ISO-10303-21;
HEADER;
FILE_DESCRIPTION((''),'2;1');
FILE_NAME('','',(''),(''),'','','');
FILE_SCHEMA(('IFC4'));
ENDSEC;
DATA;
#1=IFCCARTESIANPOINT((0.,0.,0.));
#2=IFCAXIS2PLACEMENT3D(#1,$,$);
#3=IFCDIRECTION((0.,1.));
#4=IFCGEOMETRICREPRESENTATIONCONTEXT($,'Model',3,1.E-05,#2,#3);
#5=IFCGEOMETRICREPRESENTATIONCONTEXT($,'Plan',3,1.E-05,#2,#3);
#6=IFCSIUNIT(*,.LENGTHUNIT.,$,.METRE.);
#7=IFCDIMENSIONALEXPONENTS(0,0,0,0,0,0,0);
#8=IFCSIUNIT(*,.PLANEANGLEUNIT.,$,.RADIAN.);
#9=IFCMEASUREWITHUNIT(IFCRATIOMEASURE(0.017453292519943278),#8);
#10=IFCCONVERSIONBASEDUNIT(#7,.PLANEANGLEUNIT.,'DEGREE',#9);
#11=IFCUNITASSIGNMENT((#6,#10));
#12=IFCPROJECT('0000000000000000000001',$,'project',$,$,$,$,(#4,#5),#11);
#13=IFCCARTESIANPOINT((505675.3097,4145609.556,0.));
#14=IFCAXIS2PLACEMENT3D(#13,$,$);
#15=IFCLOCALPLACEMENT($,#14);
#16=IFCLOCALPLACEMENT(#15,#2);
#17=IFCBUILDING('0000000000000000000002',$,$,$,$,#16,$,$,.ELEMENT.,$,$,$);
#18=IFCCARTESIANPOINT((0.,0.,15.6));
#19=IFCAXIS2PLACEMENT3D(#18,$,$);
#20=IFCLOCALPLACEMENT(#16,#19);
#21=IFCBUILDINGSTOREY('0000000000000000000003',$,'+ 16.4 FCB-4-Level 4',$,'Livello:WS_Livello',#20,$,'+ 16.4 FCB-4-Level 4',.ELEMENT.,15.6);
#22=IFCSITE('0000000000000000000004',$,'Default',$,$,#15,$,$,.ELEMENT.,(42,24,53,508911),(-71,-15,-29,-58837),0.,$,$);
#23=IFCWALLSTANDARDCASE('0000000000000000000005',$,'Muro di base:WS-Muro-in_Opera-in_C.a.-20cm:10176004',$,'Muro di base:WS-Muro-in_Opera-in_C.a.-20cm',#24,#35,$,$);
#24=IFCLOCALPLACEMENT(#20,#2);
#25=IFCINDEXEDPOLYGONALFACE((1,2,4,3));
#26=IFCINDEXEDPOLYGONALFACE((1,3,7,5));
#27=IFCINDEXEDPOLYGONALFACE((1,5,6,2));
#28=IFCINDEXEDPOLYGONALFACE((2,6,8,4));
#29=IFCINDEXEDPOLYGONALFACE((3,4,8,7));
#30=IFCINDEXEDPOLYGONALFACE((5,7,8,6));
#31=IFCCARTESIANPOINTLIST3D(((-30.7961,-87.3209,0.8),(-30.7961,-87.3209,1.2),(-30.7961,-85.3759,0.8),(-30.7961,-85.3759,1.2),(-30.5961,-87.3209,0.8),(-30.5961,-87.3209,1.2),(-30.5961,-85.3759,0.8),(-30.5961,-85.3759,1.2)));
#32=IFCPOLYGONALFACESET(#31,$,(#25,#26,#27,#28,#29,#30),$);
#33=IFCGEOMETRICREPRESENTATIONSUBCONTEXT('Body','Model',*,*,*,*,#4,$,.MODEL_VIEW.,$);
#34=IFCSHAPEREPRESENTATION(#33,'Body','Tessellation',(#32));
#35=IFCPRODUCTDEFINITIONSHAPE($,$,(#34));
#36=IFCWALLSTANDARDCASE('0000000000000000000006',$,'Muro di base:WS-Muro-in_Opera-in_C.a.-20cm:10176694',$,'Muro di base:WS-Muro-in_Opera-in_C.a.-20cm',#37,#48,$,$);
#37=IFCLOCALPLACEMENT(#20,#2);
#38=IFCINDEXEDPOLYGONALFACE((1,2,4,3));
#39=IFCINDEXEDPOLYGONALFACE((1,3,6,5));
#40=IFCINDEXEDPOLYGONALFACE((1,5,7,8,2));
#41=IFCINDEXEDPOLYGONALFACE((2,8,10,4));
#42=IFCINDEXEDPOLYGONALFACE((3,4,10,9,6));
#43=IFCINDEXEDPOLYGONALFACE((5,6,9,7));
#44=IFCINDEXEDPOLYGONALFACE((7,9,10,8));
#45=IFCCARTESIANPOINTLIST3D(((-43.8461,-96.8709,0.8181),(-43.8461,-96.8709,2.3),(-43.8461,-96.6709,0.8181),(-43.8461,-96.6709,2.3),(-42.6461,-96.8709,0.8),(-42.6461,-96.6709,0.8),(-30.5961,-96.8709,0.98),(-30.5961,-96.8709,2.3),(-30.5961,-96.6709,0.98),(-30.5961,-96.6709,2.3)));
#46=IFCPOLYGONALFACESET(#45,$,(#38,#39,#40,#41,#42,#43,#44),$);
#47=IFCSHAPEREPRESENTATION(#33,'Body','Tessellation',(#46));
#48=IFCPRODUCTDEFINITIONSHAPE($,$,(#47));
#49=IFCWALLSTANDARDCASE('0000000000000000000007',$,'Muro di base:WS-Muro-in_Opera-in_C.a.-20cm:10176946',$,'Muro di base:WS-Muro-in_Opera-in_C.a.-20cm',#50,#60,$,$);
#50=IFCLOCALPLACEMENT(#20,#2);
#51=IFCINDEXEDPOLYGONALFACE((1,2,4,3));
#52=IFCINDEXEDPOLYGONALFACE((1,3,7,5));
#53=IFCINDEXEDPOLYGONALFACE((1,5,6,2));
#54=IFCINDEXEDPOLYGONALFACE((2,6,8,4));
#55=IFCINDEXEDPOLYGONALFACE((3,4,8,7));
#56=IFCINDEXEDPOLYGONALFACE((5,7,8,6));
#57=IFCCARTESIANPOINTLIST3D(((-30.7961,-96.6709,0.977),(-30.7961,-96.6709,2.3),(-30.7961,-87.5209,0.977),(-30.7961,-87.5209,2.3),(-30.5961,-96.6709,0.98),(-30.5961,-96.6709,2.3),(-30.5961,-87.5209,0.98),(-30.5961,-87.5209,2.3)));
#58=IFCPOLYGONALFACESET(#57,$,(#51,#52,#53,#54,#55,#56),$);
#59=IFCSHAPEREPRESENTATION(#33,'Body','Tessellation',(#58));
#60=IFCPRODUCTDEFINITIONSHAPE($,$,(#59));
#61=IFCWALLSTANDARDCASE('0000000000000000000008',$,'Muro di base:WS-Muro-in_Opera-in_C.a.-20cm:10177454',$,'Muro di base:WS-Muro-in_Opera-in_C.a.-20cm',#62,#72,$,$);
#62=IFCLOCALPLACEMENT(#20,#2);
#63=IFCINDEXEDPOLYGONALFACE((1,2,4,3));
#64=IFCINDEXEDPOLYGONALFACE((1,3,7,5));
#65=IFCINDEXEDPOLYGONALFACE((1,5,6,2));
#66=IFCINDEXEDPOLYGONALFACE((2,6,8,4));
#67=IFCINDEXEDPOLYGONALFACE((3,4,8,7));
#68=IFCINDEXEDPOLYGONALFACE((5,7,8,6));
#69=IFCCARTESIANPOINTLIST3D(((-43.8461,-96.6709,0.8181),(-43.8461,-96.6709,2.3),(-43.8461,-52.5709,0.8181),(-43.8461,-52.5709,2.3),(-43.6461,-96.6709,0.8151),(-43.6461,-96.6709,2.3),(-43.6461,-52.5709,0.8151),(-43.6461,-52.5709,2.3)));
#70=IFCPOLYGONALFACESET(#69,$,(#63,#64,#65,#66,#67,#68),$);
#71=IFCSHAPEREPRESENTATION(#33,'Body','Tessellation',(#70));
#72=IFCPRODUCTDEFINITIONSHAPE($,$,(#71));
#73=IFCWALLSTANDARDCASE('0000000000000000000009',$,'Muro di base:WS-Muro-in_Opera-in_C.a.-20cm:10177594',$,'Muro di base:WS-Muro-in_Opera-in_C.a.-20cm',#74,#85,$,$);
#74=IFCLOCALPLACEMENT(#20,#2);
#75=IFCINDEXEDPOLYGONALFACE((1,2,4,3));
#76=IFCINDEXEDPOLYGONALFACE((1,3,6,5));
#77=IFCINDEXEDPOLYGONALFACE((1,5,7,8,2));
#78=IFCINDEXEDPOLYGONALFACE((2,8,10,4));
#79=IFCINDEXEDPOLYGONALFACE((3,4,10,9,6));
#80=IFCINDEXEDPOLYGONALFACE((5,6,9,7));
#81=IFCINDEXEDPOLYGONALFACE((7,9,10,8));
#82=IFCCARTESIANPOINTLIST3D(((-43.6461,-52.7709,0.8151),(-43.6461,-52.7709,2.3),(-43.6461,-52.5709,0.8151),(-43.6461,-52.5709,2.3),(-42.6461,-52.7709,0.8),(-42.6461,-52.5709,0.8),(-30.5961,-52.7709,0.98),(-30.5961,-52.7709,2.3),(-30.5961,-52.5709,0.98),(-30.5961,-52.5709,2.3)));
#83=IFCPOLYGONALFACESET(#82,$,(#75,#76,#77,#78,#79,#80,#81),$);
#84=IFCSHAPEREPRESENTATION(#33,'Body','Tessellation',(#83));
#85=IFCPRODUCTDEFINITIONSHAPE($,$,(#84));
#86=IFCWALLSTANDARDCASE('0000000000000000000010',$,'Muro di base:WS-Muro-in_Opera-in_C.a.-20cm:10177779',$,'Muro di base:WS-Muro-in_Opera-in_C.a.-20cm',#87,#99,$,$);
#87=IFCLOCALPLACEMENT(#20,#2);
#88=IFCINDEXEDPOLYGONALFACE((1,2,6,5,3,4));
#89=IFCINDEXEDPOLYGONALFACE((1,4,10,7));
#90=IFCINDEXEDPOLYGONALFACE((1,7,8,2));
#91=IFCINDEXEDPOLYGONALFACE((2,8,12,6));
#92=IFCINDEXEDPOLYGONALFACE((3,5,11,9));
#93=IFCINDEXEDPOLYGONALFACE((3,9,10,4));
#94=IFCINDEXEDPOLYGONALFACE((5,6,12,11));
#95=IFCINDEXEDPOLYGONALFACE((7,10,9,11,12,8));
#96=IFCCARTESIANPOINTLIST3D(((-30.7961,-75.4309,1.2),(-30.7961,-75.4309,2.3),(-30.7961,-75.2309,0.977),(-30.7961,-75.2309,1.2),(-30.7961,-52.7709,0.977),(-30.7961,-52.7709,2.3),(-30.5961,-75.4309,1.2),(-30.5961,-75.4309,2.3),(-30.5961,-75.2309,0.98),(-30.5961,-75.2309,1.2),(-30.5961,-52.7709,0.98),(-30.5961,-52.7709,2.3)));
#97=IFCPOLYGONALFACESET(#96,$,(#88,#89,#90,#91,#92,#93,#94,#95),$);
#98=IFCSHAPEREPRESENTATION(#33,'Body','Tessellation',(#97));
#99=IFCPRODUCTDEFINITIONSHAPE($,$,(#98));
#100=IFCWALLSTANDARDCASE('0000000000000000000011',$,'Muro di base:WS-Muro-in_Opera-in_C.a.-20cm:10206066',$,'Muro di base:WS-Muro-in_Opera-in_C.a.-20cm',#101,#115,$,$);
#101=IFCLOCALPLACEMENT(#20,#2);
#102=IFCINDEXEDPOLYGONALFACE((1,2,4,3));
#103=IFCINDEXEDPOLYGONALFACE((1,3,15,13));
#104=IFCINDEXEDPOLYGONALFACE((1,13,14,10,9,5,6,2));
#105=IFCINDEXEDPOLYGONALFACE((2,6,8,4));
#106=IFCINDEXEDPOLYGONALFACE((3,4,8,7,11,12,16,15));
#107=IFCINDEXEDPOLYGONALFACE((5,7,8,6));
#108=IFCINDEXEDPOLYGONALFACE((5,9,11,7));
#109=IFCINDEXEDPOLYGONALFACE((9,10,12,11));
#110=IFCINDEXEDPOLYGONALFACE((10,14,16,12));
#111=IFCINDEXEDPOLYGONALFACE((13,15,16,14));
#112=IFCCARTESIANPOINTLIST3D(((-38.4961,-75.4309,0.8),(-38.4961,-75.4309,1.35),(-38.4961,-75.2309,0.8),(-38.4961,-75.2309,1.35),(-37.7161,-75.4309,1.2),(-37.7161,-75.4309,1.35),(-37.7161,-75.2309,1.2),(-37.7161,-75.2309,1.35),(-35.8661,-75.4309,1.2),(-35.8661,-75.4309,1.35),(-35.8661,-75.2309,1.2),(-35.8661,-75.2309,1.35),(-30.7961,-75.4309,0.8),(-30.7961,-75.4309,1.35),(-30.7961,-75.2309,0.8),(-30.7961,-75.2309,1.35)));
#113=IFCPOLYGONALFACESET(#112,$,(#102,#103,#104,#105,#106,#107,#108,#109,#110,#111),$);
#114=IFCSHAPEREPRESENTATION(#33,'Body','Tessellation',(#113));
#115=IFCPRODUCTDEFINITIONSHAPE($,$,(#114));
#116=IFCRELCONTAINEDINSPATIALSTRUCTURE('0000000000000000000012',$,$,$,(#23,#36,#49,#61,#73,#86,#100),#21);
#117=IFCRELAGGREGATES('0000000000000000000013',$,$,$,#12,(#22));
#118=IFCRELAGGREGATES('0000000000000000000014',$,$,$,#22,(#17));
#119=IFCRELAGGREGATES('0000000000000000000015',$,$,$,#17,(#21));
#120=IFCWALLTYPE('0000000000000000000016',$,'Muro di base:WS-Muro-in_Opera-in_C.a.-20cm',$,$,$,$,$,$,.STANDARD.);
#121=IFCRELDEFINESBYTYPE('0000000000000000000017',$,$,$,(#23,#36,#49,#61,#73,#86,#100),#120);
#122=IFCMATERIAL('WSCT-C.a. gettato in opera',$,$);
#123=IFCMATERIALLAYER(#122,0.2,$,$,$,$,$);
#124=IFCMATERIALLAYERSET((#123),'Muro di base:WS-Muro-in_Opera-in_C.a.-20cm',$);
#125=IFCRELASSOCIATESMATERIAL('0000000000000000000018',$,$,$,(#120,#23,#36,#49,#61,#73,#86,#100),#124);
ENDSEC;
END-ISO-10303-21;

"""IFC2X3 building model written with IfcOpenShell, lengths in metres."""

from ifc_helpers import new_model, entity, si_unit, converted_unit, direction, frame, frame_2d, origin, place, context, subcontext, project, spatial, polyline, rectangle, extrude, clip, bounded_halfspace, material, layer, layer_set, layer_usage, type_object, element, save


model = new_model("IFC2X3")

# Units and contexts
model_context = context("Model", 3, precision=1e-05, world=origin(), true_north=direction((0.0, 1.0)))
plan_context = context("Plan", 3, precision=1e-05, world=origin(), true_north=direction((0.0, 1.0)))
body_context = subcontext(model_context, "Body", "Model", "MODEL_VIEW")
ifc_project = project(units=[si_unit("LENGTHUNIT", "METRE"), converted_unit("PLANEANGLEUNIT", "DEGREE", entity("IfcRatioMeasure", 0.017453292519943278), si_unit("PLANEANGLEUNIT", "RADIAN"), dimensions=[0, 0, 0, 0, 0, 0, 0])], contexts=[model_context, plan_context])

# Site, building, storey
site_placement = place(None, frame((505675.3097, 4145609.556, 0.0)))
site = spatial("IfcSite", under=ifc_project, at=site_placement, Name="Default", CompositionType="ELEMENT", RefLatitude=(42, 24, 53, 508911), RefLongitude=(-71, -15, -29, -58837), RefElevation=0.0)
building_placement = place(site_placement, origin())
building = spatial("IfcBuilding", under=site, at=building_placement, CompositionType="ELEMENT")
storey_placement = place(building_placement, frame((0.0, 0.0, 15.6)))
storey = spatial("IfcBuildingStorey", under=building, at=storey_placement, Name="+ 16.4 FCB-4-Level 4", ObjectType="Livello:WS_Livello", LongName="+ 16.4 FCB-4-Level 4", CompositionType="ELEMENT", Elevation=15.6)

# Shared definitions
ifc_material_1 = material(Name="WSCT-C.a. gettato in opera")
ifc_layer_1 = layer(ifc_material_1, 0.2)
ifc_layer_set_1 = layer_set([ifc_layer_1], Name="Muro di base:WS-Muro-in_Opera-in_C.a.-20cm")
ifc_layer_usage_1 = layer_usage(ifc_layer_set_1, "AXIS2", "NEGATIVE", 0.1)
wall_type = type_object("IfcWallType", Name="Muro di base:WS-Muro-in_Opera-in_C.a.-20cm", PredefinedType="STANDARD", material=ifc_layer_set_1)

# Walls
wall_1_placement = place(storey_placement, frame((-30.6961, -87.3209, 0.8), z_axis=(0.0, 0.0, 1.0), x_axis=(0.0, 1.0, 0.0)))
element("IfcWallStandardCase", 1, at=wall_1_placement, inside=storey, type_object=wall_type, material=ifc_layer_usage_1, Name="Muro di base:WS-Muro-in_Opera-in_C.a.-20cm:10176004", ObjectType="Muro di base:WS-Muro-in_Opera-in_C.a.-20cm", context=body_context, shape_type="Clipping", body=[
    clip(extrude(rectangle(XDim=1.945, YDim=0.2, at=frame_2d((0.9725, 0.0), x_axis=(-1.0, 0.0))), origin(), (0.0, 0.0, 1.0), 0.4), bounded_halfspace(frame((1.945, -0.1, 0.0)), True, frame((1.945, -0.1, 0.0)), polyline([(0.0, 0.0), (0.0, 0.2), (-1.945, 0.2), (-1.945, 0.0), (0.0, 0.0)]))),
])
wall_2_placement = place(storey_placement, frame((-43.8461, -96.7709, 0.8)))
element("IfcWallStandardCase", 2, at=wall_2_placement, inside=storey, type_object=wall_type, material=ifc_layer_usage_1, Name="Muro di base:WS-Muro-in_Opera-in_C.a.-20cm:10176694", ObjectType="Muro di base:WS-Muro-in_Opera-in_C.a.-20cm", context=body_context, shape_type="Clipping", body=[
    clip(clip(extrude(rectangle(XDim=13.25, YDim=0.2, at=frame_2d((6.625, 0.0), x_axis=(-1.0, 0.0))), origin(), (0.0, 0.0, 1.0), 1.5), bounded_halfspace(frame((1.2, -0.1, 0.0), z_axis=(0.015093, 0.0, 0.999886), x_axis=(0.0, -1.0, 0.0)), True, frame((1.2, -0.1, 0.0)), polyline([(0.0, 0.0), (0.0, 0.2), (-1.0, 0.2), (-1.2, 0.2), (-1.2, 0.0), (0.0, 0.0)]))), bounded_halfspace(frame((13.25, -0.1, 0.18), z_axis=(-0.014936, 0.0, 0.999888), x_axis=(-0.999888, 0.0, -0.014936)), True, frame((13.25, -0.1, 0.18)), polyline([(0.0, 0.0), (0.0, 0.2), (-0.2, 0.2), (-12.05, 0.2), (-12.05, 0.0), (0.0, 0.0)]))),
])
wall_3_placement = place(storey_placement, frame((-30.6961, -96.6709, 0.977), z_axis=(0.0, 0.0, 1.0), x_axis=(0.0, 1.0, 0.0)))
element("IfcWallStandardCase", 3, at=wall_3_placement, inside=storey, type_object=wall_type, material=ifc_layer_usage_1, Name="Muro di base:WS-Muro-in_Opera-in_C.a.-20cm:10176946", ObjectType="Muro di base:WS-Muro-in_Opera-in_C.a.-20cm", context=body_context, shape_type="Clipping", body=[
    clip(extrude(rectangle(XDim=9.15, YDim=0.2, at=frame_2d((4.575, 0.0), x_axis=(-1.0, 0.0))), origin(), (0.0, 0.0, 1.0), 1.323), bounded_halfspace(frame((9.15, -0.1, 0.003), z_axis=(0.0, 0.014936, 0.999888), x_axis=(0.0, 0.999888, -0.014936)), True, frame((9.15, -0.1, 0.003)), polyline([(0.0, 0.0), (0.0, 0.2), (-9.15, 0.2), (-9.15, 0.0), (0.0, 0.0)]))),
])
wall_4_placement = place(storey_placement, frame((-43.7461, -96.6709, 0.8151), z_axis=(0.0, 0.0, 1.0), x_axis=(0.0, 1.0, 0.0)))
element("IfcWallStandardCase", 4, at=wall_4_placement, inside=storey, type_object=wall_type, material=ifc_layer_usage_1, Name="Muro di base:WS-Muro-in_Opera-in_C.a.-20cm:10177454", ObjectType="Muro di base:WS-Muro-in_Opera-in_C.a.-20cm", context=body_context, shape_type="Clipping", body=[
    clip(extrude(rectangle(XDim=44.1, YDim=0.2, at=frame_2d((22.05, 0.0), x_axis=(-1.0, 0.0))), origin(), (0.0, 0.0, 1.0), 1.4849), bounded_halfspace(frame((44.1, -0.1, 0.0), z_axis=(0.0, -0.015093, 0.999886), x_axis=(-1.0, 0.0, 0.0)), True, frame((44.1, -0.1, 0.0)), polyline([(0.0, 0.0), (0.0, 0.2), (-44.1, 0.2), (-44.1, 0.0), (-0.2, 0.0), (0.0, 0.0)]))),
])
wall_5_placement = place(storey_placement, frame((-43.6461, -52.6709, 0.8)))
element("IfcWallStandardCase", 5, at=wall_5_placement, inside=storey, type_object=wall_type, material=ifc_layer_usage_1, Name="Muro di base:WS-Muro-in_Opera-in_C.a.-20cm:10177594", ObjectType="Muro di base:WS-Muro-in_Opera-in_C.a.-20cm", context=body_context, shape_type="Clipping", body=[
    clip(clip(extrude(rectangle(XDim=13.05, YDim=0.2, at=frame_2d((6.525, 0.0), x_axis=(-1.0, 0.0))), origin(), (0.0, 0.0, 1.0), 1.5), bounded_halfspace(frame((1.0, -0.1, 0.0), z_axis=(0.015093, 0.0, 0.999886), x_axis=(0.0, -1.0, 0.0)), True, frame((1.0, -0.1, 0.0)), polyline([(0.0, 0.0), (0.0, 0.2), (-1.0, 0.2), (-1.0, 0.0), (0.0, 0.0)]))), bounded_halfspace(frame((13.05, -0.1, 0.18), z_axis=(-0.014936, 0.0, 0.999888), x_axis=(-0.999888, 0.0, -0.014936)), True, frame((13.05, -0.1, 0.18)), polyline([(0.0, 0.0), (0.0, 0.2), (-12.05, 0.2), (-12.05, 0.0), (-0.2, 0.0), (0.0, 0.0)]))),
])
wall_6_placement = place(storey_placement, frame((-30.6961, -52.7709, 0.977), z_axis=(0.0, 0.0, 1.0), x_axis=(0.0, -1.0, 0.0)))
element("IfcWallStandardCase", 6, at=wall_6_placement, inside=storey, type_object=wall_type, material=ifc_layer_usage_1, Name="Muro di base:WS-Muro-in_Opera-in_C.a.-20cm:10177779", ObjectType="Muro di base:WS-Muro-in_Opera-in_C.a.-20cm", context=body_context, shape_type="Clipping", body=[
    clip(clip(clip(extrude(rectangle(XDim=22.66, YDim=0.2, at=frame_2d((11.33, 0.0), x_axis=(-1.0, 0.0))), origin(), (0.0, 0.0, 1.0), 1.323), bounded_halfspace(frame((0.0, -0.1, 0.0), z_axis=(0.0, -0.014936, 0.999888), x_axis=(0.0, -0.999888, -0.014936)), True, frame((0.0, -0.1, 0.0)), polyline([(0.0, 0.0), (22.46, 0.0), (22.46, 0.2), (0.0, 0.2), (0.0, 0.0)]))), bounded_halfspace(frame((22.46, 0.1, 0.223), z_axis=(-1.0, 0.0, 0.0), x_axis=(0.0, -1.0, 0.0)), True, frame((22.46, 0.1, 0.223), z_axis=(-1.0, 0.0, 0.0), x_axis=(0.0, -1.0, 0.0)), polyline([(0.0, 0.0), (0.0, -0.22), (0.2, -0.223), (0.2, 0.0), (0.0, 0.0)]))), bounded_halfspace(frame((22.46, -0.1, 0.223), z_axis=(0.0, 0.0, 1.0), x_axis=(0.0, -1.0, 0.0)), True, frame((22.46, -0.1, 0.223), z_axis=(0.0, 0.0, 1.0), x_axis=(0.0, -1.0, 0.0)), polyline([(0.0, 0.0), (0.0, 0.2), (-0.2, 0.2), (-0.2, 0.0), (0.0, 0.0)]))),
])

# Wall, opening
wall_7_placement = place(storey_placement, frame((-38.4961, -75.3309, 0.8)))
wall_7 = element("IfcWallStandardCase", 7, at=wall_7_placement, inside=storey, type_object=wall_type, material=ifc_layer_usage_1, Name="Muro di base:WS-Muro-in_Opera-in_C.a.-20cm:10206066", ObjectType="Muro di base:WS-Muro-in_Opera-in_C.a.-20cm", context=body_context, shape_type="Clipping", body=[
    clip(extrude(rectangle(XDim=7.7, YDim=0.2, at=frame_2d((3.85, 0.0), x_axis=(-1.0, 0.0))), origin(), (0.0, 0.0, 1.0), 0.55), bounded_halfspace(frame((7.7, -0.1, 0.0), z_axis=(0.0, 0.0, 1.0), x_axis=(0.0, 1.0, 0.0)), True, frame((7.7, -0.1, 0.0)), polyline([(0.0, 0.0), (0.0, 0.2), (-7.7, 0.2), (-7.7, 0.0), (0.0, 0.0)]))),
])
opening_1_placement = place(wall_7_placement, origin())
element("IfcOpeningElement", 8, at=opening_1_placement, cuts=wall_7, ObjectType="Opening", context=body_context, shape_type="SweptSolid", body=[
    extrude(rectangle(XDim=0.15, YDim=1.85, at=frame_2d((0.0, 0.0), x_axis=(0.0, 1.0))), frame((1.705, 0.1, 0.475), z_axis=(0.0, -1.0, 0.0), x_axis=(-1.0, 0.0, 0.0)), (0.0, 0.0, 1.0), 0.2),
])

save(model, "model.ifc")
